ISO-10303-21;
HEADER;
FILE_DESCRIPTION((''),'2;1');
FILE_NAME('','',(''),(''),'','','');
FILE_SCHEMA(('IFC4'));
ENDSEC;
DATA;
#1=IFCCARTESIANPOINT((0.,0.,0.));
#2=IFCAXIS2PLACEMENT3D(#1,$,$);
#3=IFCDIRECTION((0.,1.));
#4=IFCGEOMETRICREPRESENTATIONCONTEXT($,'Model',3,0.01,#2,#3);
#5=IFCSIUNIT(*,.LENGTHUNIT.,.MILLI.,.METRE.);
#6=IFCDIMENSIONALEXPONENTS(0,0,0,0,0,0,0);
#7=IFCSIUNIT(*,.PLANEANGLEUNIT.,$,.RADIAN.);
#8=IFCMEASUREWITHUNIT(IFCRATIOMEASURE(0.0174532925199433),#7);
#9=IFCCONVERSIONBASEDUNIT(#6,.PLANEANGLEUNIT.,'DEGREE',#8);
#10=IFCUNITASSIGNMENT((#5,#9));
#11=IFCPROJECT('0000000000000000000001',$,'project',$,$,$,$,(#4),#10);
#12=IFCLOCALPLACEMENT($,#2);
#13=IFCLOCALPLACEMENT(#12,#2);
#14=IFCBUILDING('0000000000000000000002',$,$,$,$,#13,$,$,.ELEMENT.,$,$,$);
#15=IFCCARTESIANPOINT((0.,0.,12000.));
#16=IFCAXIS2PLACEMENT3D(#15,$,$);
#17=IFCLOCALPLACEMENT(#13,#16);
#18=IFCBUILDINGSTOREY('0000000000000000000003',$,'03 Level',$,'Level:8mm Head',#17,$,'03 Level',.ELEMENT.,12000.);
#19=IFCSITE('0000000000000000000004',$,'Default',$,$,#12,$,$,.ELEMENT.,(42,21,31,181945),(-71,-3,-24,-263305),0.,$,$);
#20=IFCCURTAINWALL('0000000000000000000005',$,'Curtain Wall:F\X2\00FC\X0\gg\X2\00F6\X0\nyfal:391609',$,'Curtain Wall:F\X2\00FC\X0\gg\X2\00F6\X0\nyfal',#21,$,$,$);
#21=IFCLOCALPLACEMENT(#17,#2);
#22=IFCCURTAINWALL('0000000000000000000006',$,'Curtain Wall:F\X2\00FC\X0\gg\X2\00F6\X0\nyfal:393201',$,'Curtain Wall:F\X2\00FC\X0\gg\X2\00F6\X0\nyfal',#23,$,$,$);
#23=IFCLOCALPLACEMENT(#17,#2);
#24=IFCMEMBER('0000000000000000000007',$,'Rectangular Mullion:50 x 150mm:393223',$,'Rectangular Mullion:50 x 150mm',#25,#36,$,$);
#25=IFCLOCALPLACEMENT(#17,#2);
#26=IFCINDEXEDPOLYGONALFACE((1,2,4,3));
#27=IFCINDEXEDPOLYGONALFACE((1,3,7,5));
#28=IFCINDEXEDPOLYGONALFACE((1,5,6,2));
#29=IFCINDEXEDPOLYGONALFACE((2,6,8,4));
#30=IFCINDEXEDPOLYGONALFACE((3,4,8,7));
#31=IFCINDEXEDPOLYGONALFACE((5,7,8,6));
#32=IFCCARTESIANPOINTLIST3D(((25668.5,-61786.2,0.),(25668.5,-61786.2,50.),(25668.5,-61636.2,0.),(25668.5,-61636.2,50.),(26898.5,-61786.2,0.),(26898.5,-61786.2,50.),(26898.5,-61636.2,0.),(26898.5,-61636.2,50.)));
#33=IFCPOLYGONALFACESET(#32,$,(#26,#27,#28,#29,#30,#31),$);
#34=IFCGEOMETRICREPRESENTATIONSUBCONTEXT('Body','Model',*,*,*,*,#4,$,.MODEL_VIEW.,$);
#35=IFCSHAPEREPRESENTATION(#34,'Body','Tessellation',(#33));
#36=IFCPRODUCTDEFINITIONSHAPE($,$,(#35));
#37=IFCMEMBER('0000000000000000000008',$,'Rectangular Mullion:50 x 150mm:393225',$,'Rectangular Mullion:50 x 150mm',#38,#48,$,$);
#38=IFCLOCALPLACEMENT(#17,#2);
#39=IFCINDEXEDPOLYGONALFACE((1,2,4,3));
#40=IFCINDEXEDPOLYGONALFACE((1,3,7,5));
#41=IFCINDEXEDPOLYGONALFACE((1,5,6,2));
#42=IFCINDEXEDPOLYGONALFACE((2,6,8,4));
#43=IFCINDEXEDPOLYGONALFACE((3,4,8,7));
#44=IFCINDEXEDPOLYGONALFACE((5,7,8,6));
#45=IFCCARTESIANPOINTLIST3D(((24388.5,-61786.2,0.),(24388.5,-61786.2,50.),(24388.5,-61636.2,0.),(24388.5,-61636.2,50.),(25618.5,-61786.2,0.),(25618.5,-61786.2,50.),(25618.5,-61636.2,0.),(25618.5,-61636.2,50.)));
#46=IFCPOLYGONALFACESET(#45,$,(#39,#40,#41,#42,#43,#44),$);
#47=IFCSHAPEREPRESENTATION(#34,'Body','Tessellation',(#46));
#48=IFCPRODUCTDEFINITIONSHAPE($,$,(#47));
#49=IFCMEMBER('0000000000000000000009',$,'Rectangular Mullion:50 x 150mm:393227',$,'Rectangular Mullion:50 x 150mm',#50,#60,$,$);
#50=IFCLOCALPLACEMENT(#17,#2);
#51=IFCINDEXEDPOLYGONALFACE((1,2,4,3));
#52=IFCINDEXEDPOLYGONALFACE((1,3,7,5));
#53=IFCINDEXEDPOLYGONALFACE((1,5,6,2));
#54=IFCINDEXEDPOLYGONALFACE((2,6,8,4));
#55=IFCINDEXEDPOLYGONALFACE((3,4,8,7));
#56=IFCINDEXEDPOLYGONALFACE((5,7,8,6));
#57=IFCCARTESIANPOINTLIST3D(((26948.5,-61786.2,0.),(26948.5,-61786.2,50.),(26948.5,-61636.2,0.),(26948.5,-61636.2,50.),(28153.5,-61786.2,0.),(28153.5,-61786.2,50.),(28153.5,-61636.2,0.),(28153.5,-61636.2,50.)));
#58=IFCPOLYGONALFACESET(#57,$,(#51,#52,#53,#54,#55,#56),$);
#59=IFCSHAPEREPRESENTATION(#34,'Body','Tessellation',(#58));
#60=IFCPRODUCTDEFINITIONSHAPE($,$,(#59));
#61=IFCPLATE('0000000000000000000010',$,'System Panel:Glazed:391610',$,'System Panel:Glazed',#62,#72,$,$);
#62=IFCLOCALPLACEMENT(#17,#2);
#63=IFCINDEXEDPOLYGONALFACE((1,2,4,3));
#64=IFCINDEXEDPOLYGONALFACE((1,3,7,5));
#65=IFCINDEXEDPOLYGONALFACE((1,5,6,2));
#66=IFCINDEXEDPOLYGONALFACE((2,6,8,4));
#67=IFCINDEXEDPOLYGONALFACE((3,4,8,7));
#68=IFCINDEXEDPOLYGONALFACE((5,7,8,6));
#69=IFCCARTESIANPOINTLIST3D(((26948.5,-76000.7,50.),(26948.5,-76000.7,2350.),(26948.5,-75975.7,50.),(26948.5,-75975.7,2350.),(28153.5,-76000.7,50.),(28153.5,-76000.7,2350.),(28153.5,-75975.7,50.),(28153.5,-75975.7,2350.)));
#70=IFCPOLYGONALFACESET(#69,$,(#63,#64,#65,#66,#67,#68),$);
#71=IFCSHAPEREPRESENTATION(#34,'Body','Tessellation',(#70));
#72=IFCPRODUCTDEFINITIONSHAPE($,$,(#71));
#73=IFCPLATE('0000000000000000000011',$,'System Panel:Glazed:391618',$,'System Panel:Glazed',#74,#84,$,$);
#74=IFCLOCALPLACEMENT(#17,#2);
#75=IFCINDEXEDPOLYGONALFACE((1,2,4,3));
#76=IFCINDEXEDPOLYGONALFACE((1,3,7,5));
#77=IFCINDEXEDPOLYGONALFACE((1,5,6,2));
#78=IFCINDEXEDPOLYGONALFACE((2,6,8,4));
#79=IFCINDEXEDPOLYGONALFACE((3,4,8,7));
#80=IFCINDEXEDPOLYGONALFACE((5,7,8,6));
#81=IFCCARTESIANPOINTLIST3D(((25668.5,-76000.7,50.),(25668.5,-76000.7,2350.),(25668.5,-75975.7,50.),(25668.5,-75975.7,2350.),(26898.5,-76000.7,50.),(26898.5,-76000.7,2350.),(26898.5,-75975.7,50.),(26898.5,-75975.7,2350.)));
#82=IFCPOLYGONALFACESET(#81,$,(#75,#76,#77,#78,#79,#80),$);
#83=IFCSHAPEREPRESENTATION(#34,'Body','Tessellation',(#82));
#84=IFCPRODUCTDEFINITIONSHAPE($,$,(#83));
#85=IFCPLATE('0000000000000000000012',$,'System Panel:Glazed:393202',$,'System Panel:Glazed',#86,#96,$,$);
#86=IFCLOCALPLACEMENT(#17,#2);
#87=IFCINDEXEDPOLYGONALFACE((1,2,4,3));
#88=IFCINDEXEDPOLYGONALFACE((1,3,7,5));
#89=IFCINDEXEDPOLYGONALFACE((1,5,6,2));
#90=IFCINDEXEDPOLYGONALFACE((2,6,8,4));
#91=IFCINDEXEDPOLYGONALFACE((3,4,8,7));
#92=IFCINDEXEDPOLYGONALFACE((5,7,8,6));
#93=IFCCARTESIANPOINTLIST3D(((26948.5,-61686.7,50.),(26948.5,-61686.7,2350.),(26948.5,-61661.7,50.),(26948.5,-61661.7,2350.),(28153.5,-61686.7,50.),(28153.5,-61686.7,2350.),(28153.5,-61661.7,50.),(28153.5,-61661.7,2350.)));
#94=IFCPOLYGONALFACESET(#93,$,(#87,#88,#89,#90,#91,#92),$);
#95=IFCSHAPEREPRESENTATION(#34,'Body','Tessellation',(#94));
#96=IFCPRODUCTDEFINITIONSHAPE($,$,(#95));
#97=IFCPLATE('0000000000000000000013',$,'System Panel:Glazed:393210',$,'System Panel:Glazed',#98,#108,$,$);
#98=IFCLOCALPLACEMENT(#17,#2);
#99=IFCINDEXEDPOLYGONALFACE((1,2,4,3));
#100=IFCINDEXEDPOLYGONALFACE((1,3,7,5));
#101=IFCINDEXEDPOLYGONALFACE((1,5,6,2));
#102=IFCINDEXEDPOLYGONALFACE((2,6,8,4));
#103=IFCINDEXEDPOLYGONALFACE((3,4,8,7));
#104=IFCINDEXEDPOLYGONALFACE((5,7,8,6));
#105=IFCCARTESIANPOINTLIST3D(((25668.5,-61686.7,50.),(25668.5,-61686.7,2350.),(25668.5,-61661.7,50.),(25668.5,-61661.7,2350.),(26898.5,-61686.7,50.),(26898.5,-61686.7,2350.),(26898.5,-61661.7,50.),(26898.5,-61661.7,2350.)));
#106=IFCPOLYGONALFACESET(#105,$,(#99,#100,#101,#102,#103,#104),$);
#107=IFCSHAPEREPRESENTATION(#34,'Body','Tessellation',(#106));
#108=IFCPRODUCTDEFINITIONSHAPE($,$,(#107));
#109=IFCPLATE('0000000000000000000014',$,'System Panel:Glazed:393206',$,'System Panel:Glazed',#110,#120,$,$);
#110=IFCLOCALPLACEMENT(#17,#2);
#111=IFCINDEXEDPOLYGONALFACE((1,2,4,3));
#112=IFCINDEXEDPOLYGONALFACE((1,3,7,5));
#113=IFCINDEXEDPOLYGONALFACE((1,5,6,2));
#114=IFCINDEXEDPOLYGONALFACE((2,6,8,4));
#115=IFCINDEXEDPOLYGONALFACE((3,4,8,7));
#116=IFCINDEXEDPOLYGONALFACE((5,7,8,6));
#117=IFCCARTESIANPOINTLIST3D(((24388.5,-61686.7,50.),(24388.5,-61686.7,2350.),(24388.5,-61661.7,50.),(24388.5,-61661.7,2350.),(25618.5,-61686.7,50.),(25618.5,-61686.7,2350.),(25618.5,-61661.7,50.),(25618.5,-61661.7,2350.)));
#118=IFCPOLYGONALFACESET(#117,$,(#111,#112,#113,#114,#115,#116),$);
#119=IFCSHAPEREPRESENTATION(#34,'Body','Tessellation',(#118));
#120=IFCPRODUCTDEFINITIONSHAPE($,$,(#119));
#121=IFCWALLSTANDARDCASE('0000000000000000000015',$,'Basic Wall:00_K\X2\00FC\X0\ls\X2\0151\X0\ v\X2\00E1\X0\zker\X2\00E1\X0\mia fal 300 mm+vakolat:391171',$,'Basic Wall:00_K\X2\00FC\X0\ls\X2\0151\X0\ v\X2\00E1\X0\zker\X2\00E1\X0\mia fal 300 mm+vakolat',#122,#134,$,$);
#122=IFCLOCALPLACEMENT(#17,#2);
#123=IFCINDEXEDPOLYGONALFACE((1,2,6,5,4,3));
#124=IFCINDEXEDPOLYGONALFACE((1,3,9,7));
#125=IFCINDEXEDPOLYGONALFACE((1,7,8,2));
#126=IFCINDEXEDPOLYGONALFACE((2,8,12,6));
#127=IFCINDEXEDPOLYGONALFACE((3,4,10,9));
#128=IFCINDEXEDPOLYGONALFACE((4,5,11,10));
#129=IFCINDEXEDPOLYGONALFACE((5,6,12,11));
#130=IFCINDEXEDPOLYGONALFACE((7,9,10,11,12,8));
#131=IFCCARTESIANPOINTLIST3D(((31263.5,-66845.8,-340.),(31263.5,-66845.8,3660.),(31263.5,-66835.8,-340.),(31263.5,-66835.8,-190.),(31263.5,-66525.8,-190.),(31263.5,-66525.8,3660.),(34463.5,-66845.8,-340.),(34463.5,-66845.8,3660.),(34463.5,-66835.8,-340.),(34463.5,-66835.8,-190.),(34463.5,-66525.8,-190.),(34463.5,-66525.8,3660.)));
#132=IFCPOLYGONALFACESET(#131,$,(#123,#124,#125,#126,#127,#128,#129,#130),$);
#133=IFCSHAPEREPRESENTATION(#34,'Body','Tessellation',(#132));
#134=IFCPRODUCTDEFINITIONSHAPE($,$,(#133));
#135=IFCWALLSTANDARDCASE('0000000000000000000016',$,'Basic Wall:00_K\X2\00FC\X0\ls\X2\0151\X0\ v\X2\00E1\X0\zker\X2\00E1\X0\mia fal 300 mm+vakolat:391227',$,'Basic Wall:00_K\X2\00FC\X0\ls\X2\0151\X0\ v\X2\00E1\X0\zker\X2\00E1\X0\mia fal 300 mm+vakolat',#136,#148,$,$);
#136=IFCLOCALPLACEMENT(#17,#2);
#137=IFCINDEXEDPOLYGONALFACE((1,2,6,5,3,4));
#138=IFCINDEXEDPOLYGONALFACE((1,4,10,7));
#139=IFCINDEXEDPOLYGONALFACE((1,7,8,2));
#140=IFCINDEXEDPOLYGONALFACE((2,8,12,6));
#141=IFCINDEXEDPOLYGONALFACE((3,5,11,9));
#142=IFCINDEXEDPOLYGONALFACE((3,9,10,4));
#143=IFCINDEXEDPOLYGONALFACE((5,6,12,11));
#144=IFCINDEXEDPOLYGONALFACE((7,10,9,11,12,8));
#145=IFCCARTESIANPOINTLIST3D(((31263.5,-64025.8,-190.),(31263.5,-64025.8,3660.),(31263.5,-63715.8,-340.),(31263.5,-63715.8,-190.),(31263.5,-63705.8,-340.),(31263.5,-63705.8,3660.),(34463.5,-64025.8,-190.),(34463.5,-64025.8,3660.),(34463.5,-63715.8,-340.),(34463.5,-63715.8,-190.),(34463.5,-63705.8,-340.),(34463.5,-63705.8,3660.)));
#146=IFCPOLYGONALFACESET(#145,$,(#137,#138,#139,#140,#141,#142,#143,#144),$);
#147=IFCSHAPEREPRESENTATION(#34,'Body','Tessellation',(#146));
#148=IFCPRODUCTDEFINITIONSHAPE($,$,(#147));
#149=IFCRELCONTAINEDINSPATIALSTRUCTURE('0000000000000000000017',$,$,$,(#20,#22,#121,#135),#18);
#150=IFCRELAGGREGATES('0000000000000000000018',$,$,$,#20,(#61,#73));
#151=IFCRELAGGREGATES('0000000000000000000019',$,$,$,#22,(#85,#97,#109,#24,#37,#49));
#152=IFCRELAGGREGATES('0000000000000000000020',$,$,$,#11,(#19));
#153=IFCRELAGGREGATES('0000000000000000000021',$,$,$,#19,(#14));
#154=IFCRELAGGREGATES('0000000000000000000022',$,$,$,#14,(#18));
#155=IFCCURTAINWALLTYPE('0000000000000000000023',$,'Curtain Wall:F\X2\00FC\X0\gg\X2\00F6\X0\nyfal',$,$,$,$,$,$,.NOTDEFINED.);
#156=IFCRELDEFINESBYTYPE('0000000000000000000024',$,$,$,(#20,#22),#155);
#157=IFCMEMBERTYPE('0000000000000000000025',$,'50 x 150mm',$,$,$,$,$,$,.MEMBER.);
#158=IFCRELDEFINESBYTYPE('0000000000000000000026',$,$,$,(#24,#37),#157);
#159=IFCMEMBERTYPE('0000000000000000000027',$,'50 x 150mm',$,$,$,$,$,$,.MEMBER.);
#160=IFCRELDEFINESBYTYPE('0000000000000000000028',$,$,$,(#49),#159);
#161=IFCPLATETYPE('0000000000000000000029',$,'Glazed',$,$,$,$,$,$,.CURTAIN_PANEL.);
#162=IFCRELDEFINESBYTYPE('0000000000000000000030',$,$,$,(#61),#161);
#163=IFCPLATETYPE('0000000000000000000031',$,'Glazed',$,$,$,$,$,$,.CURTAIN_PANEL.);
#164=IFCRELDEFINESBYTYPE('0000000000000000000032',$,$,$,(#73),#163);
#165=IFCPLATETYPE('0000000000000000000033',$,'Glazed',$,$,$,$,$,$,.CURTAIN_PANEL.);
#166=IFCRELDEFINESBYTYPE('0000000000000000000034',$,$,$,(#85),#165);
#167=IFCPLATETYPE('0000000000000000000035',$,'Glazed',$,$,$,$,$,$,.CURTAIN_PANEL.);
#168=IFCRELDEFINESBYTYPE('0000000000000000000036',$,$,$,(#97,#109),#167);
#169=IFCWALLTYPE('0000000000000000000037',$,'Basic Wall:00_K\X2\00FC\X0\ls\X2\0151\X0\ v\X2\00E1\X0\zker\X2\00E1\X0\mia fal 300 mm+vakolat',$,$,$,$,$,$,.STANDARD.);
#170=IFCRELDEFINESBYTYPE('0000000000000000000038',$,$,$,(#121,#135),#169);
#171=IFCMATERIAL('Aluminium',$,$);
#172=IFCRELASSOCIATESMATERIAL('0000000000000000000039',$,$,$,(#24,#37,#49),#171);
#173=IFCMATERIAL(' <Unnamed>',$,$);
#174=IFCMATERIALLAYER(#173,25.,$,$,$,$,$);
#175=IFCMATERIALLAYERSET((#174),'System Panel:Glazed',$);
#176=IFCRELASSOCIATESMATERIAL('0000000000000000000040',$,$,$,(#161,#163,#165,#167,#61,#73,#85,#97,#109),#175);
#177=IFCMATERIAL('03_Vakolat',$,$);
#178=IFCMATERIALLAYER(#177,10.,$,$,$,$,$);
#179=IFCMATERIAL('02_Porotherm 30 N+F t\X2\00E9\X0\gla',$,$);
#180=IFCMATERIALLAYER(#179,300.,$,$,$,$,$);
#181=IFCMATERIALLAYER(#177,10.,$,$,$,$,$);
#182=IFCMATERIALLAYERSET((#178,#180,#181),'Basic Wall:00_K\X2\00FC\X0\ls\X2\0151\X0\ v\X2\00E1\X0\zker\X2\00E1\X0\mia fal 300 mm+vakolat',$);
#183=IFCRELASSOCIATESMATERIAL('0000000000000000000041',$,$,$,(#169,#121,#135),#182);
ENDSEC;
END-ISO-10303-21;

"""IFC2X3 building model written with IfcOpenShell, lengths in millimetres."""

from ifc_helpers import new_model, entity, si_unit, converted_unit, direction, frame, frame_2d, origin, origin_2d_with_axis, place, context, subcontext, project, spatial, polyline, rectangle, extrude, clip, bounded_halfspace, source, transform, mapped, material, layer, layer_set, layer_usage, type_object, type_shapes, element, aggregate, save


model = new_model("IFC2X3")

# Units and contexts
model_context = context("Model", 3, precision=0.01, world=origin(), true_north=direction((0.0, 1.0)))
body_context = subcontext(model_context, "Body", "Model", "MODEL_VIEW")
ifc_project = project(units=[si_unit("LENGTHUNIT", "METRE", prefix="MILLI"), converted_unit("PLANEANGLEUNIT", "DEGREE", entity("IfcRatioMeasure", 0.0174532925199433), si_unit("PLANEANGLEUNIT", "RADIAN"), dimensions=[0, 0, 0, 0, 0, 0, 0])], contexts=[model_context])

# Site, building, storey
site_placement = place(None, origin())
site = spatial("IfcSite", under=ifc_project, at=site_placement, Name="Default", CompositionType="ELEMENT", RefLatitude=(42, 21, 31, 181945), RefLongitude=(-71, -3, -24, -263305), RefElevation=0.0)
building_placement = place(site_placement, origin())
building = spatial("IfcBuilding", under=site, at=building_placement, CompositionType="ELEMENT")
storey_placement = place(building_placement, frame((0.0, 0.0, 12000.0)))
storey = spatial("IfcBuildingStorey", under=building, at=storey_placement, Name="03 Level", ObjectType="Level:8mm Head", LongName="03 Level", CompositionType="ELEMENT", Elevation=12000.0)

# Curtain walls, members
curtain_wall_type = type_object("IfcCurtainWallType", Name="Curtain Wall:Függönyfal", PredefinedType="NOTDEFINED")
curtain_wall_1_placement = place(storey_placement, frame((0.0, 0.0, -12000.0)))
curtain_wall_1 = element("IfcCurtainWall", 1, at=curtain_wall_1_placement, inside=storey, type_object=curtain_wall_type, Name="Curtain Wall:Függönyfal:391609", ObjectType="Curtain Wall:Függönyfal")
ifc_material_1 = material(Name="Aluminium")
curtain_wall_2_placement = place(storey_placement, frame((0.0, 0.0, -12000.0)))
curtain_wall_2 = element("IfcCurtainWall", 2, at=curtain_wall_2_placement, inside=storey, type_object=curtain_wall_type, Name="Curtain Wall:Függönyfal:393201", ObjectType="Curtain Wall:Függönyfal")
member_type_1 = type_object("IfcMemberType", Name="50 x 150mm", PredefinedType="MEMBER")
shared_shape_1 = source(origin(), body_context, "Body", "SweptSolid", [
    extrude(rectangle(XDim=150.0, YDim=50.0, at=origin_2d_with_axis()), frame((-25.0, 0.0, -1230.0), z_axis=(0.0, 0.0, 1.0), x_axis=(0.0, -1.0, 0.0)), (0.0, 0.0, 1.0), 1230.0),
])
type_shapes(member_type_1, [shared_shape_1])
member_1_placement = place(storey_placement, frame((26898.5, -61711.2, 0.0), z_axis=(1.0, 0.0, 0.0), x_axis=(0.0, 0.0, -1.0)))
member_1 = element("IfcMember", 3, at=member_1_placement, type_object=member_type_1, material=ifc_material_1, Name="Rectangular Mullion:50 x 150mm:393223", ObjectType="Rectangular Mullion:50 x 150mm", context=body_context, shape_type="MappedRepresentation", body=[
    mapped(shared_shape_1, transform((0.0, 0.0, 0.0), scale=1.0)),
])
member_2_placement = place(storey_placement, frame((25618.5, -61711.2, 0.0), z_axis=(1.0, 0.0, 0.0), x_axis=(0.0, 0.0, -1.0)))
member_2 = element("IfcMember", 4, at=member_2_placement, type_object=member_type_1, material=ifc_material_1, Name="Rectangular Mullion:50 x 150mm:393225", ObjectType="Rectangular Mullion:50 x 150mm", context=body_context, shape_type="MappedRepresentation", body=[
    mapped(shared_shape_1, transform((0.0, 0.0, 0.0), scale=1.0)),
])
member_type_2 = type_object("IfcMemberType", Name="50 x 150mm", PredefinedType="MEMBER")
shared_shape_2 = source(origin(), body_context, "Body", "SweptSolid", [
    extrude(rectangle(XDim=150.0, YDim=50.0, at=origin_2d_with_axis()), frame((-25.0, 0.0, -1205.0), z_axis=(0.0, 0.0, 1.0), x_axis=(0.0, -1.0, 0.0)), (0.0, 0.0, 1.0), 1205.0),
])
type_shapes(member_type_2, [shared_shape_2])
member_3_placement = place(storey_placement, frame((28153.5, -61711.2, 0.0), z_axis=(1.0, 0.0, 0.0), x_axis=(0.0, 0.0, -1.0)))
member_3 = element("IfcMember", 5, at=member_3_placement, type_object=member_type_2, material=ifc_material_1, Name="Rectangular Mullion:50 x 150mm:393227", ObjectType="Rectangular Mullion:50 x 150mm", context=body_context, shape_type="MappedRepresentation", body=[
    mapped(shared_shape_2, transform((0.0, 0.0, 0.0), scale=1.0)),
])

# Plates
ifc_material_2 = material(Name=" <Unnamed>")
ifc_layer_1 = layer(ifc_material_2, 25.0)
ifc_layer_set_1 = layer_set([ifc_layer_1], Name="System Panel:Glazed")
ifc_layer_usage_1 = layer_usage(ifc_layer_set_1, "AXIS3", "POSITIVE", 0.1)
plate_type_1 = type_object("IfcPlateType", Name="Glazed", PredefinedType="CURTAIN_PANEL", material=ifc_layer_set_1)
shared_shape_3 = source(origin(), body_context, "Body", "SweptSolid", [
    extrude(rectangle(XDim=25.0, YDim=1205.0, at=origin_2d_with_axis()), frame((602.5, 12.5, 0.0), z_axis=(0.0, 0.0, 1.0), x_axis=(0.0, 1.0, 0.0)), (0.0, 0.0, 1.0), 2300.0),
])
type_shapes(plate_type_1, [shared_shape_3])
plate_1_placement = place(curtain_wall_1_placement, frame((28153.5, -75975.7, 12050.0), z_axis=(0.0, 0.0, 1.0), x_axis=(-1.0, 0.0, 0.0)))
plate_1 = element("IfcPlate", 6, at=plate_1_placement, type_object=plate_type_1, material=ifc_layer_usage_1, Name="System Panel:Glazed:391610", ObjectType="System Panel:Glazed", context=body_context, shape_type="MappedRepresentation", body=[
    mapped(shared_shape_3, transform((0.0, 0.0, 0.0), scale=1.0)),
])
ifc_layer_usage_2 = layer_usage(ifc_layer_set_1, "AXIS3", "POSITIVE", 0.1)
plate_type_2 = type_object("IfcPlateType", Name="Glazed", PredefinedType="CURTAIN_PANEL", material=ifc_layer_set_1)
shared_shape_4 = source(origin(), body_context, "Body", "SweptSolid", [
    extrude(rectangle(XDim=25.0, YDim=1230.0, at=origin_2d_with_axis()), frame((615.0, 12.5, 0.0), z_axis=(0.0, 0.0, 1.0), x_axis=(0.0, 1.0, 0.0)), (0.0, 0.0, 1.0), 2300.0),
])
type_shapes(plate_type_2, [shared_shape_4])
plate_2_placement = place(curtain_wall_1_placement, frame((26898.5, -75975.7, 12050.0), z_axis=(0.0, 0.0, 1.0), x_axis=(-1.0, 0.0, 0.0)))
plate_2 = element("IfcPlate", 7, at=plate_2_placement, type_object=plate_type_2, material=ifc_layer_usage_2, Name="System Panel:Glazed:391618", ObjectType="System Panel:Glazed", context=body_context, shape_type="MappedRepresentation", body=[
    mapped(shared_shape_4, transform((0.0, 0.0, 0.0), scale=1.0)),
])
aggregate(curtain_wall_1, [plate_1, plate_2])
ifc_layer_usage_3 = layer_usage(ifc_layer_set_1, "AXIS3", "POSITIVE", 0.1)
plate_type_3 = type_object("IfcPlateType", Name="Glazed", PredefinedType="CURTAIN_PANEL", material=ifc_layer_set_1)
shared_shape_5 = source(origin(), body_context, "Body", "SweptSolid", [
    extrude(rectangle(XDim=25.0, YDim=1205.0, at=frame_2d((0.0, 0.0), x_axis=(1.0, 0.0))), frame((602.5, 12.5, 0.0), z_axis=(0.0, 0.0, 1.0), x_axis=(0.0, 1.0, 0.0)), (0.0, 0.0, 1.0), 2300.0),
])
type_shapes(plate_type_3, [shared_shape_5])
plate_3_placement = place(curtain_wall_2_placement, frame((28153.5, -61661.7, 12050.0), z_axis=(0.0, 0.0, 1.0), x_axis=(-1.0, 0.0, 0.0)))
plate_3 = element("IfcPlate", 8, at=plate_3_placement, type_object=plate_type_3, material=ifc_layer_usage_3, Name="System Panel:Glazed:393202", ObjectType="System Panel:Glazed", context=body_context, shape_type="MappedRepresentation", body=[
    mapped(shared_shape_5, transform((0.0, 0.0, 0.0), scale=1.0)),
])
ifc_layer_usage_4 = layer_usage(ifc_layer_set_1, "AXIS3", "POSITIVE", 0.1)
plate_type_4 = type_object("IfcPlateType", Name="Glazed", PredefinedType="CURTAIN_PANEL", material=ifc_layer_set_1)
shared_shape_6 = source(origin(), body_context, "Body", "SweptSolid", [
    extrude(rectangle(XDim=25.0, YDim=1230.0, at=frame_2d((0.0, 0.0), x_axis=(1.0, 0.0))), frame((615.0, 12.5, 0.0), z_axis=(0.0, 0.0, 1.0), x_axis=(0.0, 1.0, 0.0)), (0.0, 0.0, 1.0), 2300.0),
])
type_shapes(plate_type_4, [shared_shape_6])
plate_4_placement = place(curtain_wall_2_placement, frame((26898.5, -61661.7, 12050.0), z_axis=(0.0, 0.0, 1.0), x_axis=(-1.0, 0.0, 0.0)))
plate_4 = element("IfcPlate", 9, at=plate_4_placement, type_object=plate_type_4, material=ifc_layer_usage_4, Name="System Panel:Glazed:393210", ObjectType="System Panel:Glazed", context=body_context, shape_type="MappedRepresentation", body=[
    mapped(shared_shape_6, transform((0.0, 0.0, 0.0), scale=1.0)),
])
ifc_layer_usage_5 = layer_usage(ifc_layer_set_1, "AXIS3", "POSITIVE", 0.1)
plate_5_placement = place(curtain_wall_2_placement, frame((25618.5, -61661.7, 12050.0), z_axis=(0.0, 0.0, 1.0), x_axis=(-1.0, 0.0, 0.0)))
plate_5 = element("IfcPlate", 10, at=plate_5_placement, type_object=plate_type_4, material=ifc_layer_usage_5, Name="System Panel:Glazed:393206", ObjectType="System Panel:Glazed", context=body_context, shape_type="MappedRepresentation", body=[
    mapped(shared_shape_6, transform((0.0, 0.0, 0.0), scale=1.0)),
])
aggregate(curtain_wall_2, [plate_3, plate_4, plate_5, member_1, member_2, member_3])

# Walls
ifc_material_3 = material(Name="03_Vakolat")
ifc_layer_2 = layer(ifc_material_3, 10.0)
ifc_material_4 = material(Name="02_Porotherm 30 N+F tégla")
ifc_layer_3 = layer(ifc_material_4, 300.0)
ifc_layer_4 = layer(ifc_material_3, 10.0)
ifc_layer_set_2 = layer_set([ifc_layer_2, ifc_layer_3, ifc_layer_4], Name="Basic Wall:00_Külső vázkerámia fal 300 mm+vakolat")
ifc_layer_usage_6 = layer_usage(ifc_layer_set_2, "AXIS2", "NEGATIVE", 160.0)
wall_type_1 = type_object("IfcWallType", Name="Basic Wall:00_Külső vázkerámia fal 300 mm+vakolat", PredefinedType="STANDARD", material=ifc_layer_set_2)
wall_1_placement = place(storey_placement, frame((31263.5, -66685.8, -340.0)))
element("IfcWallStandardCase", 11, at=wall_1_placement, inside=storey, type_object=wall_type_1, material=ifc_layer_usage_6, Name="Basic Wall:00_Külső vázkerámia fal 300 mm+vakolat:391171", ObjectType="Basic Wall:00_Külső vázkerámia fal 300 mm+vakolat", context=body_context, shape_type="Clipping", body=[
    clip(clip(extrude(rectangle(XDim=3200.0, YDim=320.0, at=frame_2d((1600.0, 0.0), x_axis=(-1.0, 0.0))), origin(), (0.0, 0.0, 1.0), 4000.0), bounded_halfspace(frame((3200.0, -150.0, 150.0), z_axis=(0.0, 0.0, 1.0), x_axis=(0.0, 1.0, 0.0)), True, frame((3200.0, -150.0, 150.0), z_axis=(0.0, 0.0, 1.0), x_axis=(0.0, 1.0, 0.0)), polyline([(0.0, 0.0), (310.0, 0.0), (310.0, 3200.0), (0.0, 3200.0), (0.0, 0.0)]))), bounded_halfspace(frame((0.0, -150.0, 150.0), z_axis=(0.0, -1.0, 0.0), x_axis=(0.0, 0.0, 1.0)), True, frame((0.0, -150.0, 150.0), z_axis=(0.0, -1.0, 0.0), x_axis=(0.0, 0.0, 1.0)), polyline([(0.0, 0.0), (-150.0, 0.0), (-150.0, -3200.0), (0.0, -3200.0), (0.0, 0.0)]))),
])
ifc_layer_usage_7 = layer_usage(ifc_layer_set_2, "AXIS2", "NEGATIVE", 160.0)
wall_2_placement = place(storey_placement, frame((31263.5, -63865.8, -340.0)))
element("IfcWallStandardCase", 12, at=wall_2_placement, inside=storey, type_object=wall_type_1, material=ifc_layer_usage_7, Name="Basic Wall:00_Külső vázkerámia fal 300 mm+vakolat:391227", ObjectType="Basic Wall:00_Külső vázkerámia fal 300 mm+vakolat", context=body_context, shape_type="Clipping", body=[
    clip(clip(extrude(rectangle(XDim=3200.0, YDim=320.0, at=frame_2d((1600.0, 0.0), x_axis=(-1.0, 0.0))), origin(), (0.0, 0.0, 1.0), 4000.0), bounded_halfspace(frame((0.0, 150.0, 150.0), z_axis=(0.0, 0.0, 1.0), x_axis=(0.0, 1.0, 0.0)), True, frame((0.0, 150.0, 150.0), z_axis=(0.0, 0.0, 1.0), x_axis=(0.0, 1.0, 0.0)), polyline([(0.0, 0.0), (-310.0, 0.0), (-310.0, -3200.0), (0.0, -3200.0), (0.0, 0.0)]))), bounded_halfspace(frame((3200.0, 150.0, 150.0), z_axis=(0.0, 1.0, 0.0), x_axis=(0.0, 0.0, 1.0)), True, frame((3200.0, 150.0, 150.0), z_axis=(0.0, 1.0, 0.0), x_axis=(0.0, 0.0, 1.0)), polyline([(0.0, 0.0), (-150.0, 0.0), (-150.0, -3200.0), (0.0, -3200.0), (0.0, 0.0)]))),
])

save(model, "model.ifc")
